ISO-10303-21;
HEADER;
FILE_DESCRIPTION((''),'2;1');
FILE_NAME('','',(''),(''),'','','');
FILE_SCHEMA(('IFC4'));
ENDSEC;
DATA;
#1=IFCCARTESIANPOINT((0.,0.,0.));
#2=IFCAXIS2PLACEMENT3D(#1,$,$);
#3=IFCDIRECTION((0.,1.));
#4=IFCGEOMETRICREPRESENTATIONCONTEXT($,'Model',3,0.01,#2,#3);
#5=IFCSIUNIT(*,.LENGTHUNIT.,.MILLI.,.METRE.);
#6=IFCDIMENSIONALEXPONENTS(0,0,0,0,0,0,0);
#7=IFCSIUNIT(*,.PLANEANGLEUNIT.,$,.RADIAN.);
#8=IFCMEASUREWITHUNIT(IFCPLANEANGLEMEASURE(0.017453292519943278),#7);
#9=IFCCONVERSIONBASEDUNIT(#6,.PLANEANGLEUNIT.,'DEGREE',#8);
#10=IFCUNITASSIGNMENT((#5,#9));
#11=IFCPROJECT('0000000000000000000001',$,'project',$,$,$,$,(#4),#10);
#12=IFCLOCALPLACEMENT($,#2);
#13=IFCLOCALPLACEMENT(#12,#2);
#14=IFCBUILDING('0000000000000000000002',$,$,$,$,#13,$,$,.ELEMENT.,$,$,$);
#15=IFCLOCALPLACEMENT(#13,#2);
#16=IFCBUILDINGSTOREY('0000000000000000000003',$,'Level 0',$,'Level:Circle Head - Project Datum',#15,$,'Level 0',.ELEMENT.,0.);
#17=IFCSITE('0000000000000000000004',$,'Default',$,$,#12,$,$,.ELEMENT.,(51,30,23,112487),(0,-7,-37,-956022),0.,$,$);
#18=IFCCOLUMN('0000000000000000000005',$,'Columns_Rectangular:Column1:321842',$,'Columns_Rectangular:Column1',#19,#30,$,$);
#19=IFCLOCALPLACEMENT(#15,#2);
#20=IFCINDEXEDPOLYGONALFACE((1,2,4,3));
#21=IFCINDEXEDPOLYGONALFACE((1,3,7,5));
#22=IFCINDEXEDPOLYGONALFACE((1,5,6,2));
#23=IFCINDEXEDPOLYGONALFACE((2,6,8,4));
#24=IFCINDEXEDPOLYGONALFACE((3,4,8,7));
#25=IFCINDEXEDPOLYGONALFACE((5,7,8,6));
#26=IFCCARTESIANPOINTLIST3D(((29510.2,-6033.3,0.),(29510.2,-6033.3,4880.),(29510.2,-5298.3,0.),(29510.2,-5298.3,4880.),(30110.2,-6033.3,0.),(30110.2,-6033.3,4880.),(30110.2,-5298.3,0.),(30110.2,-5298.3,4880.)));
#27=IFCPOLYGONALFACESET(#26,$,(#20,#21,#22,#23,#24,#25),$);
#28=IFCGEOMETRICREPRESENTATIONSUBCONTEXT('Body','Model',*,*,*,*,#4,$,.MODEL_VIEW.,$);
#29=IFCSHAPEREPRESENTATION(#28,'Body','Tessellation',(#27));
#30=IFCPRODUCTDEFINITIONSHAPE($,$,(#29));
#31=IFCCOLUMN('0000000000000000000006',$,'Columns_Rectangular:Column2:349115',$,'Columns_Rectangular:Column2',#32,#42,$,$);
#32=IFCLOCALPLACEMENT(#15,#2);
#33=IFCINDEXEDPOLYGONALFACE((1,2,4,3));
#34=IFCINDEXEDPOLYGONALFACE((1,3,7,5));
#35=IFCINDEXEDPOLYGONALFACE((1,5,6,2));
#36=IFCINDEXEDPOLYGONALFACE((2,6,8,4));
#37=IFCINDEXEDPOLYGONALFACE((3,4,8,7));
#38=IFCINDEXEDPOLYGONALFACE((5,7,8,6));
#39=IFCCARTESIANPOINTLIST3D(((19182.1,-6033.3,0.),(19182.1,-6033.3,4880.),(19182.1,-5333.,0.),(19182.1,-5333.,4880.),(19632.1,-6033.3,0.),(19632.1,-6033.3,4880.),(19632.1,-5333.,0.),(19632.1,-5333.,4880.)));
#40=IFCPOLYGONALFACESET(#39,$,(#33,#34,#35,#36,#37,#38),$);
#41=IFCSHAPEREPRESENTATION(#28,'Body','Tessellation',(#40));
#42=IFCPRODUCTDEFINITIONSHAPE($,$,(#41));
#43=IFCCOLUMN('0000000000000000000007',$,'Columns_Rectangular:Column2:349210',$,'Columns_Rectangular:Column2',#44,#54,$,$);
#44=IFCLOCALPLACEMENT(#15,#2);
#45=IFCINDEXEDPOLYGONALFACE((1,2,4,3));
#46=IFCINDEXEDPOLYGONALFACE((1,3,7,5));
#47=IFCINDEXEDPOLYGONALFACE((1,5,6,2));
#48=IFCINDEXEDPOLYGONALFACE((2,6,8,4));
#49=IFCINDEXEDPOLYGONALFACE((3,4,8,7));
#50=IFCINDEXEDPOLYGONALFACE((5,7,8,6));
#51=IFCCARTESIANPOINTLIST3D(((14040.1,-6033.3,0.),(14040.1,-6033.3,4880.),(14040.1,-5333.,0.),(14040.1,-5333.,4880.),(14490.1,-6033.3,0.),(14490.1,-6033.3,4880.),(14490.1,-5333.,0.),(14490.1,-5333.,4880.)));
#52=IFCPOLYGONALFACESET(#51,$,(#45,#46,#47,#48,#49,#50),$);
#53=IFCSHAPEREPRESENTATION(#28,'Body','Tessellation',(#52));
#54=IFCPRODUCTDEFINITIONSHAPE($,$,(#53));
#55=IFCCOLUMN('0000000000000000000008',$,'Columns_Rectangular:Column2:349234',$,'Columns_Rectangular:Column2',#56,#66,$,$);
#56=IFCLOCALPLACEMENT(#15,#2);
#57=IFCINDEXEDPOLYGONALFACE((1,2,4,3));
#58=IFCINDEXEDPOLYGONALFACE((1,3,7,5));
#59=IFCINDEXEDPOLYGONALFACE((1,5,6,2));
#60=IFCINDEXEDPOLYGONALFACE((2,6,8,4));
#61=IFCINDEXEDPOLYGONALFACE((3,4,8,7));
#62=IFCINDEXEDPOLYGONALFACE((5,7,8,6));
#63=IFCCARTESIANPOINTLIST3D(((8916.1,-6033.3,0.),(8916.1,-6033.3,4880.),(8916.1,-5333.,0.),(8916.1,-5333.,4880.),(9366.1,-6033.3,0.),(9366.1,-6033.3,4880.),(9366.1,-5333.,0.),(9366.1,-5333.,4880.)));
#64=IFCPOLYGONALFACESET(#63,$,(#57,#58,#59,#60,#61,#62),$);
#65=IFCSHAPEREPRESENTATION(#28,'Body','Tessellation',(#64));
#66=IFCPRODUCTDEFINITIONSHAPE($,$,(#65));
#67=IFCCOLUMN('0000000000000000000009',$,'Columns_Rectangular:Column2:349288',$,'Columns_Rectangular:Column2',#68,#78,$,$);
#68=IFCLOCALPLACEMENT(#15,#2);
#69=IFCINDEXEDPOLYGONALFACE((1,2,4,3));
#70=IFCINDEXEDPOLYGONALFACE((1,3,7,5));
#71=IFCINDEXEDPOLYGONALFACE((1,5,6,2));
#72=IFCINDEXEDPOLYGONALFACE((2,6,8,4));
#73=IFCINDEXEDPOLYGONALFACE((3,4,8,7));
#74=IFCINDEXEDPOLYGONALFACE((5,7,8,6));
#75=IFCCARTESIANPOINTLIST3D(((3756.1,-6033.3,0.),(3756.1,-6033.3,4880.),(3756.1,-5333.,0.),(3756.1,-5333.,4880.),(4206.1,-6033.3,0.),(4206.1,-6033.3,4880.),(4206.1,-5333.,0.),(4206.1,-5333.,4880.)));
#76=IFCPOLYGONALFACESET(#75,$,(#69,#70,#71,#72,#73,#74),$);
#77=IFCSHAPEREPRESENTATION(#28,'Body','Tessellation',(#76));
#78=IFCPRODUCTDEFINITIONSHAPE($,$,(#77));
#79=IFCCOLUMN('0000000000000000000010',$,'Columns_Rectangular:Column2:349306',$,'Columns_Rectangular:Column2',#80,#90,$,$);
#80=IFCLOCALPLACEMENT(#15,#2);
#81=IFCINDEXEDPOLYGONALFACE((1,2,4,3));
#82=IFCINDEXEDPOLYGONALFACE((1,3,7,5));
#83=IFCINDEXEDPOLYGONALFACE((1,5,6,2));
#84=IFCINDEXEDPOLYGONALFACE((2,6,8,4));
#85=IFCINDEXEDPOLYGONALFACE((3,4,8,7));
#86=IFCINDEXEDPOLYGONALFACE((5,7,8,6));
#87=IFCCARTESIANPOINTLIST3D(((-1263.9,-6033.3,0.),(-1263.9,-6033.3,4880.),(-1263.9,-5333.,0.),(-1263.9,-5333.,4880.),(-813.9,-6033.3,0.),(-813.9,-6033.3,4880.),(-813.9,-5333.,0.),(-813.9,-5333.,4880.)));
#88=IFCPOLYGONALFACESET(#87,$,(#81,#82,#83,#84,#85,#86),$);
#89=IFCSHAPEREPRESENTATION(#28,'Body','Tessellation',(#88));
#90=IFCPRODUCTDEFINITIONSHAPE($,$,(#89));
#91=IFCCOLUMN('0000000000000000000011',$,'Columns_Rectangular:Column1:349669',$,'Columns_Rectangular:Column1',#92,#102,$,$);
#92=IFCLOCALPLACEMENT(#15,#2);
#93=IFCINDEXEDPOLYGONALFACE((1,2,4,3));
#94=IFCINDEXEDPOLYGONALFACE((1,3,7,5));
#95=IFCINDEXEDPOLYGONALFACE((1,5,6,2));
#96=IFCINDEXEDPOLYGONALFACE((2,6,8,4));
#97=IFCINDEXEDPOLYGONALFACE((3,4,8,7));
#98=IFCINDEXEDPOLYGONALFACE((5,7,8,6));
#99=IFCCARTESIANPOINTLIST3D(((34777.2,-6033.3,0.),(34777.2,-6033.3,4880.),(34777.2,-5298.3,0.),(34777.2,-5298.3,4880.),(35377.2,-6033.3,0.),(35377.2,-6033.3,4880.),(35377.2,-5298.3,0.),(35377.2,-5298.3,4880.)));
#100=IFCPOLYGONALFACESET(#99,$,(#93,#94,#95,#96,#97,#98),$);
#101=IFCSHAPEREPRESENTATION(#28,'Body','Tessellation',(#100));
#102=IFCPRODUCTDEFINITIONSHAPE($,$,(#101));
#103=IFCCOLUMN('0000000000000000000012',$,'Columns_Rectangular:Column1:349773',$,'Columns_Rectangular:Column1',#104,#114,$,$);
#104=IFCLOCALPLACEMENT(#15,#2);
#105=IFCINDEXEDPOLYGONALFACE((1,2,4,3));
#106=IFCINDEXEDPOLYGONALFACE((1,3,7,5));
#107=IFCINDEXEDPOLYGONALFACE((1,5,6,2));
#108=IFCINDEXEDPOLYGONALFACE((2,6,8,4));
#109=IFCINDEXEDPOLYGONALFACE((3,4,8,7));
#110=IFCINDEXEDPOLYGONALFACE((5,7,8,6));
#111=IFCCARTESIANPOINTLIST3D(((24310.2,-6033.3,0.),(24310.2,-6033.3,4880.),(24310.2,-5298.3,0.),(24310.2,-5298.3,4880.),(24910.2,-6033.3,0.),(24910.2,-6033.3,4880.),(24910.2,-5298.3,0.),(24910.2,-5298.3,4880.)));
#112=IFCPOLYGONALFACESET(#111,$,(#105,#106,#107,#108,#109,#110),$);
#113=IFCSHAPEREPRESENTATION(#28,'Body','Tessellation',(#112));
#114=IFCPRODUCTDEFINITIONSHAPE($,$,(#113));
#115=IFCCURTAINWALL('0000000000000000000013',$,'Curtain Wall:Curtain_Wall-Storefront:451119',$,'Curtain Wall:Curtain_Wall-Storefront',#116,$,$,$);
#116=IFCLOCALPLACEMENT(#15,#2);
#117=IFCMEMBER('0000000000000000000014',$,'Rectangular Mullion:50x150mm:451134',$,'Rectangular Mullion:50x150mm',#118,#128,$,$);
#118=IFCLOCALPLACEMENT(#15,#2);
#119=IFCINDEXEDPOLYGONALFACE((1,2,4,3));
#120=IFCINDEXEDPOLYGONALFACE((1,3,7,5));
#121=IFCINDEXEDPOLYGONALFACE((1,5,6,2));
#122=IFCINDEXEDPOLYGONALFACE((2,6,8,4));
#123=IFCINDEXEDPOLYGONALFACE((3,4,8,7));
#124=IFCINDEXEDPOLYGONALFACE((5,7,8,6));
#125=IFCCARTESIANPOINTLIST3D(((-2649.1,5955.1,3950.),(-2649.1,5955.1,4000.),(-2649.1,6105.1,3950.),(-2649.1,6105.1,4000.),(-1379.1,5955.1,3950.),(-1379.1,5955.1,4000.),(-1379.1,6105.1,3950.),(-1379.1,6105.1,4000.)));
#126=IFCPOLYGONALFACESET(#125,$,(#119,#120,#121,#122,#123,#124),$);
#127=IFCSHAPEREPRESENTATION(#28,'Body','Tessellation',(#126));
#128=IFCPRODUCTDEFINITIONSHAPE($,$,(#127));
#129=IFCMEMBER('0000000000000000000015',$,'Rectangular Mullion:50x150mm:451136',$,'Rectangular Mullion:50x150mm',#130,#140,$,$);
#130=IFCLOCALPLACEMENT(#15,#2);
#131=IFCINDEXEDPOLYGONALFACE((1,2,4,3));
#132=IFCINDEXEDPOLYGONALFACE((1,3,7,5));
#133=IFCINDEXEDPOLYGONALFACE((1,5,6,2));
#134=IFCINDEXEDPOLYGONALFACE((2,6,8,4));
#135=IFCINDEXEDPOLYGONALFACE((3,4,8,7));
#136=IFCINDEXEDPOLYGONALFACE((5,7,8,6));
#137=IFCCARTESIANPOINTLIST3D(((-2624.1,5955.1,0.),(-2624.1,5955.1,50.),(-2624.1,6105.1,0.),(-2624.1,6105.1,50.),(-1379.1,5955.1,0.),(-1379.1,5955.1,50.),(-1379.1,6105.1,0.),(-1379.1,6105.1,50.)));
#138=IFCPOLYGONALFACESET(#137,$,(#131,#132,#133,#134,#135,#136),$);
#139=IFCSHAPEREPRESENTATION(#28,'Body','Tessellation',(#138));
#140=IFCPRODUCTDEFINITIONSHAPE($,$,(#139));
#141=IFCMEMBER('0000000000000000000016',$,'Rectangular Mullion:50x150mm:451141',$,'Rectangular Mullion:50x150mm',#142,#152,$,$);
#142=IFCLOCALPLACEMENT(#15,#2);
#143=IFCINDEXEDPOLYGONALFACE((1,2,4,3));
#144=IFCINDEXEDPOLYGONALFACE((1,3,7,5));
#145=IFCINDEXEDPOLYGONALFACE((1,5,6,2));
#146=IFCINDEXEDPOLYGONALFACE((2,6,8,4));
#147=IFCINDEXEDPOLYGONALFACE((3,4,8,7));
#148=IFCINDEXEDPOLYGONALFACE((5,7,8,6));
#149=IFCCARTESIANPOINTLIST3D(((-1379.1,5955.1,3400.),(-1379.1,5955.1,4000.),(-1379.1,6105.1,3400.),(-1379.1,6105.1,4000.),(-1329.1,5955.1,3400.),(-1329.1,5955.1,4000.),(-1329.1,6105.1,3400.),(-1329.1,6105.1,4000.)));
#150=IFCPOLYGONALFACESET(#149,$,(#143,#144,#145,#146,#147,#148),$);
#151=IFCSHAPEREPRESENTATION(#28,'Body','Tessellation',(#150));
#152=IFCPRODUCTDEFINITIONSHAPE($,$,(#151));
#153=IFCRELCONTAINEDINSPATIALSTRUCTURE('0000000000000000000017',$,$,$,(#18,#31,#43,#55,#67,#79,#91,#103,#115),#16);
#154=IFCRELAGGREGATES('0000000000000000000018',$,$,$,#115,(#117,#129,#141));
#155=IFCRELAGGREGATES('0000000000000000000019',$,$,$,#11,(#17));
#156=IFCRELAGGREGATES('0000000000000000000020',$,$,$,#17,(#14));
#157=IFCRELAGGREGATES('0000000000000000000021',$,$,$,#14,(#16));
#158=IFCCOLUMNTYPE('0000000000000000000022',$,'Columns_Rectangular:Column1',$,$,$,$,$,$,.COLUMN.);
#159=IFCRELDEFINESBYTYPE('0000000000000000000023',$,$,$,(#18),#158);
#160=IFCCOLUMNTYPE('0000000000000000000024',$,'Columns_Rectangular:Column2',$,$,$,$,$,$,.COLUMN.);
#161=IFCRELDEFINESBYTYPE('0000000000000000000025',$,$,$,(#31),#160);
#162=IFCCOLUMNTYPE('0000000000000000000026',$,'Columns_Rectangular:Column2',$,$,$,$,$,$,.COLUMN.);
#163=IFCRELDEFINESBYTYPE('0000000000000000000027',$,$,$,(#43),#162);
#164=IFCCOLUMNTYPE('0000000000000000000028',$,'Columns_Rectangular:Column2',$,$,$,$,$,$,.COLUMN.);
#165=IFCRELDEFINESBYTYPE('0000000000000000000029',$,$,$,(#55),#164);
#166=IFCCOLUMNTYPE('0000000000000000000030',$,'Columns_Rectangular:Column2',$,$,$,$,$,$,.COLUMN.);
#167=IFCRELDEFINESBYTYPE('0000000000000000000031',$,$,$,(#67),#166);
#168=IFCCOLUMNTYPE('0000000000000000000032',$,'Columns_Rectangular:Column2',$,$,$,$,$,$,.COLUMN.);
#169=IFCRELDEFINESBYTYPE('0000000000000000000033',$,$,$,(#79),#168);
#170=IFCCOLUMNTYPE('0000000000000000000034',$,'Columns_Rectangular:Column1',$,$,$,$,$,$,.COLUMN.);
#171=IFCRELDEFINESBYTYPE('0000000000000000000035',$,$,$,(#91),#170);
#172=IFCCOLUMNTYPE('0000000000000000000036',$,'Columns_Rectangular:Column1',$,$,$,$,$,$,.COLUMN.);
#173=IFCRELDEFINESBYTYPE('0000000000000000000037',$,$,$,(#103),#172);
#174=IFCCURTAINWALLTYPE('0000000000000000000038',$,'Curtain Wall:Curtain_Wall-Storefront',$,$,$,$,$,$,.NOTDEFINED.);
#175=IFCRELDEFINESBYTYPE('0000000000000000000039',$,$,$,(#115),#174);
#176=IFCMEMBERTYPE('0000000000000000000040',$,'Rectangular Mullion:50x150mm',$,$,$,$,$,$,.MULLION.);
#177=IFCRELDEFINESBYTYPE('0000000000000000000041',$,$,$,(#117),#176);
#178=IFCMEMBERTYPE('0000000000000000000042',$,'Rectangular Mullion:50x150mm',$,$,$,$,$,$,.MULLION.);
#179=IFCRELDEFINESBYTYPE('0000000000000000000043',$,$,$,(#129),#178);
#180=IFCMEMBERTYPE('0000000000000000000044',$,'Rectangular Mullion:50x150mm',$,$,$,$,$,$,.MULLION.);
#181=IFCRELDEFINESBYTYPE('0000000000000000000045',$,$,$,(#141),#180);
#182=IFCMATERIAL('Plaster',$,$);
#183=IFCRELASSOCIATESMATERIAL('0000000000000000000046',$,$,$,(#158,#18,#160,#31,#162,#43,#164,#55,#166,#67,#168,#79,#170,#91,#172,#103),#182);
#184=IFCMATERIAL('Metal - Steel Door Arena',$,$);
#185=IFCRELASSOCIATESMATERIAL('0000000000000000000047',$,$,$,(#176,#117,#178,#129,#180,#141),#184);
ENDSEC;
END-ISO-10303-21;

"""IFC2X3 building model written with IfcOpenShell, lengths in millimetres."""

from ifc_helpers import new_model, entity, si_unit, converted_unit, direction, frame, frame_2d, origin, origin_2d_with_axis, place, context, subcontext, project, spatial, rectangle, extrude, source, transform, mapped, material, type_object, type_shapes, element, aggregate, save


model = new_model("IFC2X3")

# Units and contexts
model_context = context("Model", 3, precision=0.01, world=origin(), true_north=direction((0.0, 1.0)))
body_context = subcontext(model_context, "Body", "Model", "MODEL_VIEW")
ifc_project = project(units=[si_unit("LENGTHUNIT", "METRE", prefix="MILLI"), converted_unit("PLANEANGLEUNIT", "DEGREE", entity("IfcPlaneAngleMeasure", 0.017453292519943278), si_unit("PLANEANGLEUNIT", "RADIAN"), dimensions=[0, 0, 0, 0, 0, 0, 0])], contexts=[model_context])

# Site, building, storey
site_placement = place(None, origin())
site = spatial("IfcSite", under=ifc_project, at=site_placement, Name="Default", CompositionType="ELEMENT", RefLatitude=(51, 30, 23, 112487), RefLongitude=(0, -7, -37, -956022), RefElevation=0.0)
building_placement = place(site_placement, origin())
building = spatial("IfcBuilding", under=site, at=building_placement, CompositionType="ELEMENT")
storey_placement = place(building_placement, origin())
storey = spatial("IfcBuildingStorey", under=building, at=storey_placement, Name="Level 0", ObjectType="Level:Circle Head - Project Datum", LongName="Level 0", CompositionType="ELEMENT", Elevation=0.0)

# Columns
ifc_material_1 = material(Name="Plaster")
column_type_1 = type_object("IfcColumnType", Name="Columns_Rectangular:Column1", PredefinedType="COLUMN", material=ifc_material_1)
shared_shape_1 = source(origin(), body_context, "Body", "SweptSolid", [
    extrude(rectangle(XDim=735.0, YDim=600.0, at=frame_2d((0.0, 0.0), x_axis=(1.0, 0.0))), frame((29810.2, -5665.8, 0.0), z_axis=(0.0, 0.0, 1.0), x_axis=(0.0, -1.0, 0.0)), (0.0, 0.0, 1.0), 4880.0),
])
type_shapes(column_type_1, [shared_shape_1])
column_1_placement = place(storey_placement, origin())
element("IfcColumn", 1, at=column_1_placement, inside=storey, type_object=column_type_1, material=ifc_material_1, Name="Columns_Rectangular:Column1:321842", ObjectType="Columns_Rectangular:Column1", context=body_context, shape_type="MappedRepresentation", body=[
    mapped(shared_shape_1, transform((0.0, 0.0, 0.0), scale=1.0)),
])
column_type_2 = type_object("IfcColumnType", Name="Columns_Rectangular:Column2", PredefinedType="COLUMN", material=ifc_material_1)
shared_shape_2 = source(origin(), body_context, "Body", "SweptSolid", [
    extrude(rectangle(XDim=700.3, YDim=450.0, at=frame_2d((0.0, 0.0), x_axis=(1.0, 0.0))), frame((19407.1, -5683.1, 0.0), z_axis=(0.0, 0.0, 1.0), x_axis=(0.0, -1.0, 0.0)), (0.0, 0.0, 1.0), 4880.0),
])
type_shapes(column_type_2, [shared_shape_2])
column_2_placement = place(storey_placement, origin())
element("IfcColumn", 2, at=column_2_placement, inside=storey, type_object=column_type_2, material=ifc_material_1, Name="Columns_Rectangular:Column2:349115", ObjectType="Columns_Rectangular:Column2", context=body_context, shape_type="MappedRepresentation", body=[
    mapped(shared_shape_2, transform((0.0, 0.0, 0.0), scale=1.0)),
])
column_type_3 = type_object("IfcColumnType", Name="Columns_Rectangular:Column2", PredefinedType="COLUMN", material=ifc_material_1)
shared_shape_3 = source(origin(), body_context, "Body", "SweptSolid", [
    extrude(rectangle(XDim=700.3, YDim=450.0, at=frame_2d((0.0, 0.0), x_axis=(1.0, 0.0))), frame((14265.1, -5683.1, 0.0), z_axis=(0.0, 0.0, 1.0), x_axis=(0.0, -1.0, 0.0)), (0.0, 0.0, 1.0), 4880.0),
])
type_shapes(column_type_3, [shared_shape_3])
column_3_placement = place(storey_placement, origin())
element("IfcColumn", 3, at=column_3_placement, inside=storey, type_object=column_type_3, material=ifc_material_1, Name="Columns_Rectangular:Column2:349210", ObjectType="Columns_Rectangular:Column2", context=body_context, shape_type="MappedRepresentation", body=[
    mapped(shared_shape_3, transform((0.0, 0.0, 0.0), scale=1.0)),
])
column_type_4 = type_object("IfcColumnType", Name="Columns_Rectangular:Column2", PredefinedType="COLUMN", material=ifc_material_1)
shared_shape_4 = source(origin(), body_context, "Body", "SweptSolid", [
    extrude(rectangle(XDim=700.3, YDim=450.0, at=frame_2d((0.0, 0.0), x_axis=(1.0, 0.0))), frame((9141.1, -5683.1, 0.0), z_axis=(0.0, 0.0, 1.0), x_axis=(0.0, -1.0, 0.0)), (0.0, 0.0, 1.0), 4880.0),
])
type_shapes(column_type_4, [shared_shape_4])
column_4_placement = place(storey_placement, origin())
element("IfcColumn", 4, at=column_4_placement, inside=storey, type_object=column_type_4, material=ifc_material_1, Name="Columns_Rectangular:Column2:349234", ObjectType="Columns_Rectangular:Column2", context=body_context, shape_type="MappedRepresentation", body=[
    mapped(shared_shape_4, transform((0.0, 0.0, 0.0), scale=1.0)),
])
column_type_5 = type_object("IfcColumnType", Name="Columns_Rectangular:Column2", PredefinedType="COLUMN", material=ifc_material_1)
shared_shape_5 = source(origin(), body_context, "Body", "SweptSolid", [
    extrude(rectangle(XDim=700.3, YDim=450.0, at=frame_2d((0.0, 0.0), x_axis=(1.0, 0.0))), frame((3981.1, -5683.1, 0.0), z_axis=(0.0, 0.0, 1.0), x_axis=(0.0, -1.0, 0.0)), (0.0, 0.0, 1.0), 4880.0),
])
type_shapes(column_type_5, [shared_shape_5])
column_5_placement = place(storey_placement, origin())
element("IfcColumn", 5, at=column_5_placement, inside=storey, type_object=column_type_5, material=ifc_material_1, Name="Columns_Rectangular:Column2:349288", ObjectType="Columns_Rectangular:Column2", context=body_context, shape_type="MappedRepresentation", body=[
    mapped(shared_shape_5, transform((0.0, 0.0, 0.0), scale=1.0)),
])
column_type_6 = type_object("IfcColumnType", Name="Columns_Rectangular:Column2", PredefinedType="COLUMN", material=ifc_material_1)
shared_shape_6 = source(origin(), body_context, "Body", "SweptSolid", [
    extrude(rectangle(XDim=700.3, YDim=450.0, at=frame_2d((0.0, 0.0), x_axis=(1.0, 0.0))), frame((-1038.9, -5683.1, 0.0), z_axis=(0.0, 0.0, 1.0), x_axis=(0.0, -1.0, 0.0)), (0.0, 0.0, 1.0), 4880.0),
])
type_shapes(column_type_6, [shared_shape_6])
column_6_placement = place(storey_placement, origin())
element("IfcColumn", 6, at=column_6_placement, inside=storey, type_object=column_type_6, material=ifc_material_1, Name="Columns_Rectangular:Column2:349306", ObjectType="Columns_Rectangular:Column2", context=body_context, shape_type="MappedRepresentation", body=[
    mapped(shared_shape_6, transform((0.0, 0.0, 0.0), scale=1.0)),
])
column_type_7 = type_object("IfcColumnType", Name="Columns_Rectangular:Column1", PredefinedType="COLUMN", material=ifc_material_1)
shared_shape_7 = source(origin(), body_context, "Body", "SweptSolid", [
    extrude(rectangle(XDim=735.0, YDim=600.0, at=frame_2d((0.0, 0.0), x_axis=(1.0, 0.0))), frame((35077.2, -5665.8, 0.0), z_axis=(0.0, 0.0, 1.0), x_axis=(0.0, -1.0, 0.0)), (0.0, 0.0, 1.0), 4880.0),
])
type_shapes(column_type_7, [shared_shape_7])
column_7_placement = place(storey_placement, origin())
element("IfcColumn", 7, at=column_7_placement, inside=storey, type_object=column_type_7, material=ifc_material_1, Name="Columns_Rectangular:Column1:349669", ObjectType="Columns_Rectangular:Column1", context=body_context, shape_type="MappedRepresentation", body=[
    mapped(shared_shape_7, transform((0.0, 0.0, 0.0), scale=1.0)),
])
column_type_8 = type_object("IfcColumnType", Name="Columns_Rectangular:Column1", PredefinedType="COLUMN", material=ifc_material_1)
shared_shape_8 = source(origin(), body_context, "Body", "SweptSolid", [
    extrude(rectangle(XDim=735.0, YDim=600.0, at=origin_2d_with_axis()), frame((24610.2, -5665.8, 0.0), z_axis=(0.0, 0.0, 1.0), x_axis=(0.0, -1.0, 0.0)), (0.0, 0.0, 1.0), 4880.0),
])
type_shapes(column_type_8, [shared_shape_8])
column_8_placement = place(storey_placement, origin())
element("IfcColumn", 8, at=column_8_placement, inside=storey, type_object=column_type_8, material=ifc_material_1, Name="Columns_Rectangular:Column1:349773", ObjectType="Columns_Rectangular:Column1", context=body_context, shape_type="MappedRepresentation", body=[
    mapped(shared_shape_8, transform((0.0, 0.0, 0.0), scale=1.0)),
])

# Curtain wall, members
curtain_wall_type = type_object("IfcCurtainWallType", Name="Curtain Wall:Curtain_Wall-Storefront", PredefinedType="NOTDEFINED")
curtain_wall_placement = place(storey_placement, origin())
curtain_wall = element("IfcCurtainWall", 9, at=curtain_wall_placement, inside=storey, type_object=curtain_wall_type, Name="Curtain Wall:Curtain_Wall-Storefront:451119", ObjectType="Curtain Wall:Curtain_Wall-Storefront")
ifc_material_2 = material(Name="Metal - Steel Door Arena")
member_type_1 = type_object("IfcMemberType", Name="Rectangular Mullion:50x150mm", PredefinedType="MULLION", material=ifc_material_2)
shared_shape_9 = source(origin(), body_context, "Body", "SweptSolid", [
    extrude(rectangle(XDim=50.0, YDim=150.0, at=origin_2d_with_axis()), frame((-25.0, 0.0, -1270.0), z_axis=(0.0, 0.0, 1.0), x_axis=(-1.0, 0.0, 0.0)), (0.0, 0.0, 1.0), 1270.0),
])
type_shapes(member_type_1, [shared_shape_9])
member_1_placement = place(curtain_wall_placement, frame((-2649.1, 6030.1, 4000.0), z_axis=(-1.0, 0.0, 0.0), x_axis=(0.0, 0.0, 1.0)))
member_1 = element("IfcMember", 10, at=member_1_placement, type_object=member_type_1, material=ifc_material_2, Name="Rectangular Mullion:50x150mm:451134", ObjectType="Rectangular Mullion:50x150mm", context=body_context, shape_type="MappedRepresentation", body=[
    mapped(shared_shape_9, transform((0.0, 0.0, 0.0), scale=1.0)),
])
member_type_2 = type_object("IfcMemberType", Name="Rectangular Mullion:50x150mm", PredefinedType="MULLION", material=ifc_material_2)
shared_shape_10 = source(origin(), body_context, "Body", "SweptSolid", [
    extrude(rectangle(XDim=50.0, YDim=150.0, at=origin_2d_with_axis()), frame((-25.0, 0.0, -1245.0), z_axis=(0.0, 0.0, 1.0), x_axis=(-1.0, 0.0, 0.0)), (0.0, 0.0, 1.0), 1245.0),
])
type_shapes(member_type_2, [shared_shape_10])
member_2_placement = place(curtain_wall_placement, frame((-1379.1, 6030.1, 0.0), z_axis=(1.0, 0.0, 0.0), x_axis=(0.0, 0.0, -1.0)))
member_2 = element("IfcMember", 11, at=member_2_placement, type_object=member_type_2, material=ifc_material_2, Name="Rectangular Mullion:50x150mm:451136", ObjectType="Rectangular Mullion:50x150mm", context=body_context, shape_type="MappedRepresentation", body=[
    mapped(shared_shape_10, transform((0.0, 0.0, 0.0), scale=1.0)),
])
member_type_3 = type_object("IfcMemberType", Name="Rectangular Mullion:50x150mm", PredefinedType="MULLION", material=ifc_material_2)
shared_shape_11 = source(origin(), body_context, "Body", "SweptSolid", [
    extrude(rectangle(XDim=50.0, YDim=150.0, at=origin_2d_with_axis()), frame((-25.0, 0.0, -600.0), z_axis=(0.0, 0.0, 1.0), x_axis=(-1.0, 0.0, 0.0)), (0.0, 0.0, 1.0), 600.0),
])
type_shapes(member_type_3, [shared_shape_11])
member_3_placement = place(curtain_wall_placement, frame((-1329.1, 6030.1, 4000.0)))
member_3 = element("IfcMember", 12, at=member_3_placement, type_object=member_type_3, material=ifc_material_2, Name="Rectangular Mullion:50x150mm:451141", ObjectType="Rectangular Mullion:50x150mm", context=body_context, shape_type="MappedRepresentation", body=[
    mapped(shared_shape_11, transform((0.0, 0.0, 0.0), scale=1.0)),
])

aggregate(curtain_wall, [member_1, member_2, member_3])

save(model, "model.ifc")
